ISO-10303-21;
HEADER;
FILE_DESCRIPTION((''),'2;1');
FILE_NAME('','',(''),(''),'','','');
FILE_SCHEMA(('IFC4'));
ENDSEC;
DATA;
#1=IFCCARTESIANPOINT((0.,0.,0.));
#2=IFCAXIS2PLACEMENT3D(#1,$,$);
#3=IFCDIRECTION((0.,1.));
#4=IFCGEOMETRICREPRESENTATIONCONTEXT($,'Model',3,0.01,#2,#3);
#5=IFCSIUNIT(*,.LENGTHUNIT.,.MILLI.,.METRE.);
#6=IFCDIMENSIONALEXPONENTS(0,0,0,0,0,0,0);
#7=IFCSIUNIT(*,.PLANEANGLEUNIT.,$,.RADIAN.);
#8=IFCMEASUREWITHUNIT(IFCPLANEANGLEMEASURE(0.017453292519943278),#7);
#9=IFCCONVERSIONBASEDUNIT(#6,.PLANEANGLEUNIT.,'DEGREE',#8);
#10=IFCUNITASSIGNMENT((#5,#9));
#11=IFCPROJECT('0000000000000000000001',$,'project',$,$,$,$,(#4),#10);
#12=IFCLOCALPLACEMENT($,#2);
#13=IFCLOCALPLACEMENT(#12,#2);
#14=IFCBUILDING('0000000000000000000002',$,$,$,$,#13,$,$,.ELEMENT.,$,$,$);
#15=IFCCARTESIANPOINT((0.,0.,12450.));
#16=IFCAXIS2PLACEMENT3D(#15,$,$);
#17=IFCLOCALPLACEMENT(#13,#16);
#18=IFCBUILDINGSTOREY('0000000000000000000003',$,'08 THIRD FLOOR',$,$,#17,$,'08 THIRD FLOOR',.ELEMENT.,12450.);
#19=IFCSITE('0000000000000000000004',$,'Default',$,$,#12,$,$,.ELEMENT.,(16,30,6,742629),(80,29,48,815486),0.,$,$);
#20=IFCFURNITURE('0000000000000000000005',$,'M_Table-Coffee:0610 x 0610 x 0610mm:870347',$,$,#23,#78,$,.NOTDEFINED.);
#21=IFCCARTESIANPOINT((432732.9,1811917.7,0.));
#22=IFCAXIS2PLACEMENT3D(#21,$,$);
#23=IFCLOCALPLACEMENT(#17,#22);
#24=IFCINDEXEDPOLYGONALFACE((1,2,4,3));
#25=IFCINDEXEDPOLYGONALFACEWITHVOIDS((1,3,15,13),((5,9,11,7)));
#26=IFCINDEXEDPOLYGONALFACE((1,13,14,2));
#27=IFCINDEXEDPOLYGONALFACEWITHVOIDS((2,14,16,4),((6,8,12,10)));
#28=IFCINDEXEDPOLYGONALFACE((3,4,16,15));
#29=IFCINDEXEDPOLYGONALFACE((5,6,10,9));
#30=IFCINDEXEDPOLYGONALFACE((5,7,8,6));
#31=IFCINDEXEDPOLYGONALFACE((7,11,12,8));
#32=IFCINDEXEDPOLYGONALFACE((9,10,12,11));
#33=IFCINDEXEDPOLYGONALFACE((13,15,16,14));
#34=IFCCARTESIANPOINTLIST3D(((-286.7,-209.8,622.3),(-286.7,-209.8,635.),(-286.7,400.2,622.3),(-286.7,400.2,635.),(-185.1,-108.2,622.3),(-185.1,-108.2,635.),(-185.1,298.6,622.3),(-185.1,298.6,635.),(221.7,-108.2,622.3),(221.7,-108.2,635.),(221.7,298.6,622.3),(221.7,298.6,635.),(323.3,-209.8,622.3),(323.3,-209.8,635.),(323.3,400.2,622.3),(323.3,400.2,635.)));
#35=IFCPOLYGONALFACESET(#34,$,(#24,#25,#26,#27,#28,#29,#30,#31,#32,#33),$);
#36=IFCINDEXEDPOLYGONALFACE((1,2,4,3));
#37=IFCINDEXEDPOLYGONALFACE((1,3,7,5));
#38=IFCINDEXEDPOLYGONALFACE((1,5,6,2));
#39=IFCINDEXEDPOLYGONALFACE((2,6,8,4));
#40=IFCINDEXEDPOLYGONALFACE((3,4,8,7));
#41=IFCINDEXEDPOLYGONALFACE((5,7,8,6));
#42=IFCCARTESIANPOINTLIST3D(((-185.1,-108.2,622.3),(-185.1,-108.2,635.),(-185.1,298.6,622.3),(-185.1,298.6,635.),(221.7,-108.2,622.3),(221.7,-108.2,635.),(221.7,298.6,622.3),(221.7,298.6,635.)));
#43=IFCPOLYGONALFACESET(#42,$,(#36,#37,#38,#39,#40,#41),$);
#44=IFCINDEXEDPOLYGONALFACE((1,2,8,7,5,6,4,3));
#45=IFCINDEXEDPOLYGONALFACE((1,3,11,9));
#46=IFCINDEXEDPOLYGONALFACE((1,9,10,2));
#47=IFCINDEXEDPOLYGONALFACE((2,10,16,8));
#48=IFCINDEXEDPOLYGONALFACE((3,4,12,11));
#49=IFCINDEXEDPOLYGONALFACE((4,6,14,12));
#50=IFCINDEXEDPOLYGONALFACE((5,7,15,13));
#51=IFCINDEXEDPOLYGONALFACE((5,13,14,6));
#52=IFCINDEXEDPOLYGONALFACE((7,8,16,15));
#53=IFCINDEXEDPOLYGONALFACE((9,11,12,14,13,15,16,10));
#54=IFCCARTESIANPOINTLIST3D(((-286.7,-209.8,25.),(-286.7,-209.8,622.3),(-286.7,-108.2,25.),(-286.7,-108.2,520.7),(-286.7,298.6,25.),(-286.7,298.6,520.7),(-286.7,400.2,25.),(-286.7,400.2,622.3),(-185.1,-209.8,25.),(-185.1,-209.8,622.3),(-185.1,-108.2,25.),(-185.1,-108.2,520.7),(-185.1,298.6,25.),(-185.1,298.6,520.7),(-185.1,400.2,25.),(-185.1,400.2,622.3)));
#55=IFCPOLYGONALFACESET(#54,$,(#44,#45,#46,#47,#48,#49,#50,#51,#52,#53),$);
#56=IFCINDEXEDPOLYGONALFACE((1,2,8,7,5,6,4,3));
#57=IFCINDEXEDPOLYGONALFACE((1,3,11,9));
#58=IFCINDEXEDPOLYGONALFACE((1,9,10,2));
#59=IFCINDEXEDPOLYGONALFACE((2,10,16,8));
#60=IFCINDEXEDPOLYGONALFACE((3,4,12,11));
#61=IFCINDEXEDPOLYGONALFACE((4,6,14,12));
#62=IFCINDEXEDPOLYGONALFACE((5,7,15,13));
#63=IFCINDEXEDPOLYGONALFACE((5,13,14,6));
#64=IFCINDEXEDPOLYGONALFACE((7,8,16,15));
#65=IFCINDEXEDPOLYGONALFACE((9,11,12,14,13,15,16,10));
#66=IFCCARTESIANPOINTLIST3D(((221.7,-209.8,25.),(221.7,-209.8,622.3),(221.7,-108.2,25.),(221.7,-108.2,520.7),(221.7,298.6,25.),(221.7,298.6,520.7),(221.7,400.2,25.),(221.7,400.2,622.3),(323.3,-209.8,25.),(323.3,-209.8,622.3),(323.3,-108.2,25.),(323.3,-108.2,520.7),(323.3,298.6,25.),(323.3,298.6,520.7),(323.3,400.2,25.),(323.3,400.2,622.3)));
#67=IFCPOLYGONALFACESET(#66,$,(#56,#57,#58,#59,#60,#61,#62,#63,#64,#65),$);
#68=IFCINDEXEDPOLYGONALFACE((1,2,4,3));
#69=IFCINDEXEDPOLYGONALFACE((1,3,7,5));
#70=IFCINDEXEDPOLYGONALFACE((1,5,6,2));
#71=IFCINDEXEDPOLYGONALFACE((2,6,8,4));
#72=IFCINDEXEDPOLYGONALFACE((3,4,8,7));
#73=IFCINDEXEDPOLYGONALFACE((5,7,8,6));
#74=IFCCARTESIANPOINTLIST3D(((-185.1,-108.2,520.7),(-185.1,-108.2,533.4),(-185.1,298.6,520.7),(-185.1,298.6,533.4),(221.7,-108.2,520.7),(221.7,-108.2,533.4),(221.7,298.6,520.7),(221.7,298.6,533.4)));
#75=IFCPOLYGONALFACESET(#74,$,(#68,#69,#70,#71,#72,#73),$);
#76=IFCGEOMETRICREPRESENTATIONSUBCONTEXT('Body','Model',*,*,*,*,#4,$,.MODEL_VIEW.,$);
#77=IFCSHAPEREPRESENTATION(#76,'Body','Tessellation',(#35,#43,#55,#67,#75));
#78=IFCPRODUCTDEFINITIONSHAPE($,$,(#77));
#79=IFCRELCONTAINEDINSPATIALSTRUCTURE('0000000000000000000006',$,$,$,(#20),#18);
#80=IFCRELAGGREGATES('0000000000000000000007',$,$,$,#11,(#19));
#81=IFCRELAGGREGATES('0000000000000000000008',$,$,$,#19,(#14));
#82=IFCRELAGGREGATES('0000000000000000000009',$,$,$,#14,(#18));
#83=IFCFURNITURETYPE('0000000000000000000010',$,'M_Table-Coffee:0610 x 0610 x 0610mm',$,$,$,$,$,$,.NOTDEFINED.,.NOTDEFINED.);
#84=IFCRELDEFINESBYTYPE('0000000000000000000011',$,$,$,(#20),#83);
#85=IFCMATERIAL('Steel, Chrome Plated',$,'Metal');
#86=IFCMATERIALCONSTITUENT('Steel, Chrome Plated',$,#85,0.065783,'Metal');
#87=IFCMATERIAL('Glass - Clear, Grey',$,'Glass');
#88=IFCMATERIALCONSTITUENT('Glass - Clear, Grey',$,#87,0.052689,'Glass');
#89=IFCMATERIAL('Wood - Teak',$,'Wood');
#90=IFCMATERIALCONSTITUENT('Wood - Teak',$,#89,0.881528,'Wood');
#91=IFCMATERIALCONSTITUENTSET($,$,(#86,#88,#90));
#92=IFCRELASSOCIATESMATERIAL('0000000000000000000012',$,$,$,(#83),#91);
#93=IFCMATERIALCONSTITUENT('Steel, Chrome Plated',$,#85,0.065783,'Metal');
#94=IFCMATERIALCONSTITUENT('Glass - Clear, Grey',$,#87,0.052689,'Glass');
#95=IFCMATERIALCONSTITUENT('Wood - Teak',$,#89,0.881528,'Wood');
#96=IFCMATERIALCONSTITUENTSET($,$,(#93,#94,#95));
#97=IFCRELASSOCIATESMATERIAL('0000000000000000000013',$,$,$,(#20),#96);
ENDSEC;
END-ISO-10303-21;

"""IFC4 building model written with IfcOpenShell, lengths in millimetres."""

from ifc_helpers import new_model, entity, si_unit, converted_unit, direction, frame, origin, place, context, subcontext, project, spatial, indexed_curve, outline, extrude, source, transform, mapped, material, constituent, constituent_set, type_object, type_shapes, element, save


model = new_model("IFC4")

# Units and contexts
model_context = context("Model", 3, precision=0.01, world=origin(), true_north=direction((0.0, 1.0)))
body_context = subcontext(model_context, "Body", "Model", "MODEL_VIEW")
ifc_project = project(units=[si_unit("LENGTHUNIT", "METRE", prefix="MILLI"), converted_unit("PLANEANGLEUNIT", "DEGREE", entity("IfcPlaneAngleMeasure", 0.017453292519943278), si_unit("PLANEANGLEUNIT", "RADIAN"), dimensions=[0, 0, 0, 0, 0, 0, 0])], contexts=[model_context])

# Site, building, storey
site_placement = place(None, origin())
site = spatial("IfcSite", under=ifc_project, at=site_placement, Name="Default", CompositionType="ELEMENT", RefLatitude=(16, 30, 6, 742629), RefLongitude=(80, 29, 48, 815486), RefElevation=0.0)
building_placement = place(site_placement, origin())
building = spatial("IfcBuilding", under=site, at=building_placement, CompositionType="ELEMENT")
storey_placement = place(building_placement, frame((0.0, 0.0, 12450.0)))
storey = spatial("IfcBuildingStorey", under=building, at=storey_placement, Name="08 THIRD FLOOR", LongName="08 THIRD FLOOR", CompositionType="ELEMENT", Elevation=12450.0)

# Furniture
ifc_material_1 = material(Name="Steel, Chrome Plated", Category="Metal")
ifc_constituent_1 = constituent(ifc_material_1, Name="Steel, Chrome Plated", Category="Metal", fraction=0.065783)
ifc_material_2 = material(Name="Glass - Clear, Grey", Category="Glass")
ifc_constituent_2 = constituent(ifc_material_2, Name="Glass - Clear, Grey", Category="Glass", fraction=0.052689)
ifc_material_3 = material(Name="Wood - Teak", Category="Wood")
ifc_constituent_3 = constituent(ifc_material_3, Name="Wood - Teak", Category="Wood", fraction=0.881528)
ifc_constituent_set_1 = constituent_set(constituents=[ifc_constituent_1, ifc_constituent_2, ifc_constituent_3])
ifc_constituent_4 = constituent(ifc_material_1, Name="Steel, Chrome Plated", Category="Metal", fraction=0.065783)
ifc_constituent_5 = constituent(ifc_material_2, Name="Glass - Clear, Grey", Category="Glass", fraction=0.052689)
ifc_constituent_6 = constituent(ifc_material_3, Name="Wood - Teak", Category="Wood", fraction=0.881528)
ifc_constituent_set_2 = constituent_set(constituents=[ifc_constituent_4, ifc_constituent_5, ifc_constituent_6])
furniture_type = type_object("IfcFurnitureType", Name="M_Table-Coffee:0610 x 0610 x 0610mm", AssemblyPlace="NOTDEFINED", PredefinedType="NOTDEFINED", material=ifc_constituent_set_2)
shared_shape_1 = source(origin(), body_context, "Body", "SweptSolid", [
    extrude(outline(indexed_curve([(-305.0, -305.0), (305.0, -305.0), (305.0, 305.0), (-305.0, 305.0), (-305.0, -305.0)], self_intersect=False), holes=[indexed_curve([(-203.4, -203.4), (-203.4, 203.4), (203.4, 203.4), (203.4, -203.4), (-203.4, -203.4)], self_intersect=False)]), frame((18.3, 95.2, 622.3), z_axis=(0.0, 0.0, 1.0), x_axis=(-1.0, 0.0, 0.0)), (0.0, 0.0, 1.0), 12.7),
    extrude(outline(indexed_curve([(-203.4, -203.4), (203.4, -203.4), (203.4, 203.4), (-203.4, 203.4), (-203.4, -203.4)], self_intersect=False)), frame((18.3, 95.2, 622.3), z_axis=(0.0, 0.0, 1.0), x_axis=(-1.0, 0.0, 0.0)), (0.0, 0.0, 1.0), 12.7),
    extrude(outline(indexed_curve([(-305.0, -324.1), (305.0, -324.1), (305.0, 273.3), (203.4, 273.3), (203.4, -222.4), (-203.4, -222.4), (-203.4, 273.3), (-305.0, 273.3), (-305.0, -324.1)], self_intersect=False)), frame((-286.7, 95.2, 298.3), z_axis=(1.0, 0.0, 0.0), x_axis=(0.0, -1.0, 0.0)), (0.0, 0.0, 1.0), 101.6),
    extrude(outline(indexed_curve([(-273.2, -305.0), (324.0, -305.0), (324.0, 305.0), (-273.2, 305.0), (-273.2, 203.4), (222.5, 203.4), (222.5, -203.4), (-273.2, -203.4), (-273.2, -305.0)], self_intersect=False)), frame((221.7, 95.2, 298.2), z_axis=(1.0, 0.0, 0.0), x_axis=(0.0, 0.0, 1.0)), (0.0, 0.0, 1.0), 101.6),
    extrude(outline(indexed_curve([(-203.4, -203.4), (203.4, -203.4), (203.4, 203.4), (-203.4, 203.4), (-203.4, -203.4)], self_intersect=False)), frame((18.3, 95.2, 520.7), z_axis=(0.0, 0.0, 1.0), x_axis=(-1.0, 0.0, 0.0)), (0.0, 0.0, 1.0), 12.7),
])
type_shapes(furniture_type, [shared_shape_1])
furniture_placement = place(storey_placement, frame((432732.9, 1811917.7, 0.0)))
element("IfcFurniture", 1, at=furniture_placement, inside=storey, type_object=furniture_type, material=ifc_constituent_set_1, Name="M_Table-Coffee:0610 x 0610 x 0610mm:870347", PredefinedType="NOTDEFINED", context=body_context, shape_type="MappedRepresentation", body=[
    mapped(shared_shape_1, transform((0.0, 0.0, 0.0), scale=1.0)),
])

save(model, "model.ifc")
